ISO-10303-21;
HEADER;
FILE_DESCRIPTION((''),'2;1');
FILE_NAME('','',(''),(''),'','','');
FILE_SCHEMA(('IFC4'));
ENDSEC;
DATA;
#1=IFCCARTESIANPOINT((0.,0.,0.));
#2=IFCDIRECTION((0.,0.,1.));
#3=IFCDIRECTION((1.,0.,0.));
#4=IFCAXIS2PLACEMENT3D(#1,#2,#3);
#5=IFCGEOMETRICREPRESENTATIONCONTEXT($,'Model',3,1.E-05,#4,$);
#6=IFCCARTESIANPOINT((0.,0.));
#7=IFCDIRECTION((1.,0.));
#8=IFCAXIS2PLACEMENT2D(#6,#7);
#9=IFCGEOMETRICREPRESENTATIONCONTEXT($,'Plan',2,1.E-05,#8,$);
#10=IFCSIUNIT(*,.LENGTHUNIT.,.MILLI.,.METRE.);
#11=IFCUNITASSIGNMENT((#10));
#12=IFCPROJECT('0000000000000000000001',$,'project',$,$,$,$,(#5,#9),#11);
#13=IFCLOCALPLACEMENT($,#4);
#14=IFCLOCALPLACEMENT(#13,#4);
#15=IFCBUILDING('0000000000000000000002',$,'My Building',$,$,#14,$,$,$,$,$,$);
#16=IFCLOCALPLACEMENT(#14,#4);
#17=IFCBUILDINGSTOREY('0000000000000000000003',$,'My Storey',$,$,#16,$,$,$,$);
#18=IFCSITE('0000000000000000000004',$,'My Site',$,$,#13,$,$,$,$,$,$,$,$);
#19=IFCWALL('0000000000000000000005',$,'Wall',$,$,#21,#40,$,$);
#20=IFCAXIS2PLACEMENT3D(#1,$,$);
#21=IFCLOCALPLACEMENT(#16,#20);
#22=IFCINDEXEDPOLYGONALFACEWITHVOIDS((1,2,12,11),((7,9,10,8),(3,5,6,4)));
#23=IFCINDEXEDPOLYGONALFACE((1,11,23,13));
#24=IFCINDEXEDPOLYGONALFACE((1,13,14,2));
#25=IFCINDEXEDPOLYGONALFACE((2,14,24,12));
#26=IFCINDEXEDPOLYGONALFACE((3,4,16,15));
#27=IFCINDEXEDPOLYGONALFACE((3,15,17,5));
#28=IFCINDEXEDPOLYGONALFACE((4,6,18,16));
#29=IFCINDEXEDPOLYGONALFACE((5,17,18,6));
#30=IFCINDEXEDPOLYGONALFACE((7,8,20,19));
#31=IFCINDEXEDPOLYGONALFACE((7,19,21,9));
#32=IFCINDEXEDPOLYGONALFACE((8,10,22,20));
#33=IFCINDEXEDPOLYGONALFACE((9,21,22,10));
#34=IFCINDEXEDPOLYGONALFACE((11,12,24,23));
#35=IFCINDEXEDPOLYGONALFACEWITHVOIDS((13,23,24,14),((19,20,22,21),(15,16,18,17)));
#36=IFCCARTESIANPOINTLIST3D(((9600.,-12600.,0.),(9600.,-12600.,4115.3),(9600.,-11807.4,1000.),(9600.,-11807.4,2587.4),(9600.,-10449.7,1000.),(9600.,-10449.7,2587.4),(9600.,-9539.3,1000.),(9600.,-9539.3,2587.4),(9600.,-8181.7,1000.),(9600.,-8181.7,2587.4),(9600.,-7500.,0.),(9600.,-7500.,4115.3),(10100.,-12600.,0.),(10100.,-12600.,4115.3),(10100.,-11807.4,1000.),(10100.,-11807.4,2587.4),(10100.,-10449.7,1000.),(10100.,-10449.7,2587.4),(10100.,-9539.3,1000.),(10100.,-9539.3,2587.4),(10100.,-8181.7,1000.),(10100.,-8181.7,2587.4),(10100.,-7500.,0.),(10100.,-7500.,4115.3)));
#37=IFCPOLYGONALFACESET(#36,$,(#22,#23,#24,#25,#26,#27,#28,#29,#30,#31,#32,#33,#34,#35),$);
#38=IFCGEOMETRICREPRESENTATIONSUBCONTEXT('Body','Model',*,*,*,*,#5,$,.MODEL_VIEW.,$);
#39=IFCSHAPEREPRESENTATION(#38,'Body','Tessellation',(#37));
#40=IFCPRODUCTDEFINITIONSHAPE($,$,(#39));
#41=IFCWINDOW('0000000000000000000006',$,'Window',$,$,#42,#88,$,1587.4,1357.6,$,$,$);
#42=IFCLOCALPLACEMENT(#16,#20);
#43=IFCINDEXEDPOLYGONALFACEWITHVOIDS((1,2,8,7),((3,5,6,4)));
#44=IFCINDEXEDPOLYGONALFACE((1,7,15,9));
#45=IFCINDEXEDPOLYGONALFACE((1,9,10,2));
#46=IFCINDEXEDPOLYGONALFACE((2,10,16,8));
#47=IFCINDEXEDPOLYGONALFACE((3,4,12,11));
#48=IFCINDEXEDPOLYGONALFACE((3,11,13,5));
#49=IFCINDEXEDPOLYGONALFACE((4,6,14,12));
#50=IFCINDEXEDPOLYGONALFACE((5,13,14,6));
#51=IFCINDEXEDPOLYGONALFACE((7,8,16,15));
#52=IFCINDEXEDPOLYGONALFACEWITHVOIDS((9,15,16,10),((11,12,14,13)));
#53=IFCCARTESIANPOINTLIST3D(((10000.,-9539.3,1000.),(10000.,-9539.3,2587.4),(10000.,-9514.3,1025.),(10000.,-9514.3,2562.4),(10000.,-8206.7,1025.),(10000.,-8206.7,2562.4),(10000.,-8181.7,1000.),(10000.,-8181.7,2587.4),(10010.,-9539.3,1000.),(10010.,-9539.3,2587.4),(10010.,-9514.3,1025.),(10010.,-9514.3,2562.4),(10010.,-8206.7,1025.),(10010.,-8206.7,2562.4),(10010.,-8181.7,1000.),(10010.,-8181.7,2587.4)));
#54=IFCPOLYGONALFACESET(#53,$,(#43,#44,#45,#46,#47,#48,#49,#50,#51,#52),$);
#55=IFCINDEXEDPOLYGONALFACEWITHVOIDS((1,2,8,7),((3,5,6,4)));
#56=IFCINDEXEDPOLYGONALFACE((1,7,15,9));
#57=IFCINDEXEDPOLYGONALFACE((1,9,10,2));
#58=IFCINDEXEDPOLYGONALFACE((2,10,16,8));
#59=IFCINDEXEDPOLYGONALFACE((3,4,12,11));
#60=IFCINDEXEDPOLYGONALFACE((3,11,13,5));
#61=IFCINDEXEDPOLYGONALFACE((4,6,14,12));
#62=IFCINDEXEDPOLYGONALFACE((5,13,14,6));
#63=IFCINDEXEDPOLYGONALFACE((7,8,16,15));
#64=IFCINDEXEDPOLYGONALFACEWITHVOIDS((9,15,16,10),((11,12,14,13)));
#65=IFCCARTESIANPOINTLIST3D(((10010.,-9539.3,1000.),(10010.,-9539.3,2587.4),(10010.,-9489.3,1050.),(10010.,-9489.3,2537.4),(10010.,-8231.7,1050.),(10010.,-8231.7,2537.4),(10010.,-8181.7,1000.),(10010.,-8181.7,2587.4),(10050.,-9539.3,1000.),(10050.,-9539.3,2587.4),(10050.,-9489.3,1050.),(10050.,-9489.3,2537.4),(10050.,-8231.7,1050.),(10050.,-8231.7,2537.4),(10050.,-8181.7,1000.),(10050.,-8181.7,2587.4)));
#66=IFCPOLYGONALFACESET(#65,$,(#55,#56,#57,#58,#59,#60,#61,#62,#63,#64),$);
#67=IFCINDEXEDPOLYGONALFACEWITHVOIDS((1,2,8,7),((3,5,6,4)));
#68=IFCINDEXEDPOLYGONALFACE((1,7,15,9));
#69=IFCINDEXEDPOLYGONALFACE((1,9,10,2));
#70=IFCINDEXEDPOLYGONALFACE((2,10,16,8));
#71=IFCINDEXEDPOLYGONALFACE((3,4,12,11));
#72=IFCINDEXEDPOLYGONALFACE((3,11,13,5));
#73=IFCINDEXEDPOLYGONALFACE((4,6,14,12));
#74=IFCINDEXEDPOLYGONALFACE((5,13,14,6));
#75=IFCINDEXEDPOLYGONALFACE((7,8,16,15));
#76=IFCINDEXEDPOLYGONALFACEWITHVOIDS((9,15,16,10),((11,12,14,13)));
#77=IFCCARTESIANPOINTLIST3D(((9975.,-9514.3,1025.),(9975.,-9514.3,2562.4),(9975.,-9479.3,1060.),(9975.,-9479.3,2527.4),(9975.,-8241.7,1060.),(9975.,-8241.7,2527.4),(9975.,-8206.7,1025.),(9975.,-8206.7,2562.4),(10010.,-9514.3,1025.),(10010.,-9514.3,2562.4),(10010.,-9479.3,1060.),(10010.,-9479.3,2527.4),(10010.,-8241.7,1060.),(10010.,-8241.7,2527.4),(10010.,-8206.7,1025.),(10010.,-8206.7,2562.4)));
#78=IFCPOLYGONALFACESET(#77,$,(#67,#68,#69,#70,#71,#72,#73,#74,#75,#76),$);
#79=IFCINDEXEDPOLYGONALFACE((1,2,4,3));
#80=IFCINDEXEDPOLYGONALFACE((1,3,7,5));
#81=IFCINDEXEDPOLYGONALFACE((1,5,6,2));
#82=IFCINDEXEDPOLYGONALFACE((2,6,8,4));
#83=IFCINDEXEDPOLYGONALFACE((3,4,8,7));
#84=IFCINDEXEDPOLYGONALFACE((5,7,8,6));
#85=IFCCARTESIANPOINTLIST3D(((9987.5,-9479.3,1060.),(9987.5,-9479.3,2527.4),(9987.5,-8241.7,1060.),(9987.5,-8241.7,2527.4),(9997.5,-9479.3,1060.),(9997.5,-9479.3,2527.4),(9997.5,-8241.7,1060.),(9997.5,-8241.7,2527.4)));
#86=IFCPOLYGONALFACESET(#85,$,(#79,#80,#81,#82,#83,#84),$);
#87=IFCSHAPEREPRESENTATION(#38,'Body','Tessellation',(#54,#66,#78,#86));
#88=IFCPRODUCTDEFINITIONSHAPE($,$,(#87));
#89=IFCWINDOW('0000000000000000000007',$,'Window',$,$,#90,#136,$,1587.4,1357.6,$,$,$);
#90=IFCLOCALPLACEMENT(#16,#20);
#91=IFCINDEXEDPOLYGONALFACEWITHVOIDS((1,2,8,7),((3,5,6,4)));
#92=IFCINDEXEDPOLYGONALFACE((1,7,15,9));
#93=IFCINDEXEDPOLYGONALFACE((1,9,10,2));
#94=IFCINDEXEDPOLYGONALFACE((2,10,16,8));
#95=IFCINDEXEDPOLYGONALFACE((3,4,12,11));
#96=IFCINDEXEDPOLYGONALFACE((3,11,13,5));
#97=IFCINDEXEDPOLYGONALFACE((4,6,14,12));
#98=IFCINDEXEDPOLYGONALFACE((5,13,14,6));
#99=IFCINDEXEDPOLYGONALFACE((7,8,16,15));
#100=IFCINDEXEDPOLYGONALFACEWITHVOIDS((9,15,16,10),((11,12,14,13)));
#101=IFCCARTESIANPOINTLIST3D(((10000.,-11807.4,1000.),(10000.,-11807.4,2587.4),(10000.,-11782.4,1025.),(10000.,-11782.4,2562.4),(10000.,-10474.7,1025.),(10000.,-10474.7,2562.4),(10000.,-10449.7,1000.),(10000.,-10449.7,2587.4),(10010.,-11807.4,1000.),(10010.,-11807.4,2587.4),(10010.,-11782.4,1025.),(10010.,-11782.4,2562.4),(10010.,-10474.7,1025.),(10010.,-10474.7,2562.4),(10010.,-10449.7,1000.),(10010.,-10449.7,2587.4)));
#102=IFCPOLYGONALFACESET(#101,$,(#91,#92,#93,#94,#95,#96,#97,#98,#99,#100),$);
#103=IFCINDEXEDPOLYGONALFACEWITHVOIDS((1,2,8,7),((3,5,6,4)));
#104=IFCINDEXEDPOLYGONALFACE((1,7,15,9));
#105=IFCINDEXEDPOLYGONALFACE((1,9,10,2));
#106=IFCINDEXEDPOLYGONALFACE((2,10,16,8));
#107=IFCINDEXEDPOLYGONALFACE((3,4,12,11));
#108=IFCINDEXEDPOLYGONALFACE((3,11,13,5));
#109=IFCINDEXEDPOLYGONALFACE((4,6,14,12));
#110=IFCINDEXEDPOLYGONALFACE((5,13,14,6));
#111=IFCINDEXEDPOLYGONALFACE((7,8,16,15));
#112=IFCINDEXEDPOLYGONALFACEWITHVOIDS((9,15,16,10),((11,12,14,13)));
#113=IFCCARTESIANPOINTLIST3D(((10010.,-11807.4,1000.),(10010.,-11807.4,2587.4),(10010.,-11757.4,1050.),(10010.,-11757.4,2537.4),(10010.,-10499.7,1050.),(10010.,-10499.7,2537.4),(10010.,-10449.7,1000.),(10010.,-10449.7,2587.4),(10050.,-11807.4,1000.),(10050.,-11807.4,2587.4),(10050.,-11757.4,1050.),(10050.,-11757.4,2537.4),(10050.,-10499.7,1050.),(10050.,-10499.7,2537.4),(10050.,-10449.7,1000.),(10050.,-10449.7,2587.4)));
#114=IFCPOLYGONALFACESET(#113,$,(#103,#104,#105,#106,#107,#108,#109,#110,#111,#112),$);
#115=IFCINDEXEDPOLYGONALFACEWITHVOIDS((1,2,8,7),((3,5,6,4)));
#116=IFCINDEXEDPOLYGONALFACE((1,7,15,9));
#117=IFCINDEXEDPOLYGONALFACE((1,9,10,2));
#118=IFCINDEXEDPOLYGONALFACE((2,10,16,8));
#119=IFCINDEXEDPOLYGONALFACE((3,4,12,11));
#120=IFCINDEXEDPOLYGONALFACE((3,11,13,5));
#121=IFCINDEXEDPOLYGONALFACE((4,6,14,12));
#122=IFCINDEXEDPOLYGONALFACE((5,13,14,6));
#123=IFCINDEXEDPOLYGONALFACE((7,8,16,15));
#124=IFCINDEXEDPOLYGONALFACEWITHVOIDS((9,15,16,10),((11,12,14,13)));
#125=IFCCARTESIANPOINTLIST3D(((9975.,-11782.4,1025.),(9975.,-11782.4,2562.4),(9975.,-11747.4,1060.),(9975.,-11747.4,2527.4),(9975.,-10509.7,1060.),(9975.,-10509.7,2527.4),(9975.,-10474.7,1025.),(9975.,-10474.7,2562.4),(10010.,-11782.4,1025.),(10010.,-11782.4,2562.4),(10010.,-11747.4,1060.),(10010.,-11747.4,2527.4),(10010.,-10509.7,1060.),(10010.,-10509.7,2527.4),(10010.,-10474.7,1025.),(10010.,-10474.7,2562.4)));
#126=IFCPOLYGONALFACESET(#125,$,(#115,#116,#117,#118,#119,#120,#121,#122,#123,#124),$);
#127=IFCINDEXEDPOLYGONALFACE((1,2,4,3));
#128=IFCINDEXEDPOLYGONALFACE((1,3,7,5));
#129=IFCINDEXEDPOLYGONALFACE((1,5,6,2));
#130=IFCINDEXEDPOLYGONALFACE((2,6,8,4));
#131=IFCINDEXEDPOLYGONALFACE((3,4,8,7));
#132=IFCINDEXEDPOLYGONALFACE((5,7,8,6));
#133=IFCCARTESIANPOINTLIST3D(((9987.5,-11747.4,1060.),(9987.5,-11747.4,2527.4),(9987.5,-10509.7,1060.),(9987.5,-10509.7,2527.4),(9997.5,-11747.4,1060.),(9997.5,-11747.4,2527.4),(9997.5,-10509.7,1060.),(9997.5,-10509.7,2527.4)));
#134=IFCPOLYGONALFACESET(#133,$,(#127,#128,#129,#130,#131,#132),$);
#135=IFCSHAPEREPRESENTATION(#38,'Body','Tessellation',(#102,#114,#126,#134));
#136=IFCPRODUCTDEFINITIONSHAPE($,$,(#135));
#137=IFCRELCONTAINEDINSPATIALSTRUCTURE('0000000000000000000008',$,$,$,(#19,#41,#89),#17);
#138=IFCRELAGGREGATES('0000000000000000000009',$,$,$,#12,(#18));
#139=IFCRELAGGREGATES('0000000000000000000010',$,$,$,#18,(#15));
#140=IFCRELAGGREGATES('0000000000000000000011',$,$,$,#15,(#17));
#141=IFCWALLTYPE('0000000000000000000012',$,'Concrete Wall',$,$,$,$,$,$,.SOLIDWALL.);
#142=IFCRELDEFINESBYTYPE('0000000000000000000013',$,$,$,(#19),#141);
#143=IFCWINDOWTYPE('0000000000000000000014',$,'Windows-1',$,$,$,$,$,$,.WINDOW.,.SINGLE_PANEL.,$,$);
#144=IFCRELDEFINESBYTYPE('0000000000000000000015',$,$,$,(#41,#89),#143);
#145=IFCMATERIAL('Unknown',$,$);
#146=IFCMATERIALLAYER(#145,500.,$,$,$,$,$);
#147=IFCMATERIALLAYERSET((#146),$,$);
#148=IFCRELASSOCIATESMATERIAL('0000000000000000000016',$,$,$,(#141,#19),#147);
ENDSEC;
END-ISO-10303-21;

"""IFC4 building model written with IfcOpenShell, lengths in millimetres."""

from ifc_helpers import new_model, entity, si_unit, frame, origin_with_axes, origin_2d_with_axis, place, context, subcontext, project, spatial, line, indexed_curve, outline, extrude, shape, source, transform, mapped, material, layer, layer_set, layer_usage, type_object, type_shapes, element, fill, save


model = new_model("IFC4")

# Units and contexts
model_context = context("Model", 3, precision=1e-05, world=origin_with_axes())
plan_context = context("Plan", 2, precision=1e-05, world=origin_2d_with_axis())
body_context_1 = subcontext(model_context, "Body", "Model", "MODEL_VIEW")
body_context_2 = subcontext(plan_context, "Body", "Plan", "PLAN_VIEW")
ifc_project = project(units=[si_unit("LENGTHUNIT", "METRE", prefix="MILLI")], contexts=[model_context, plan_context])

# Site, building, storey
site_placement = place(None, origin_with_axes())
site = spatial("IfcSite", under=ifc_project, at=site_placement, Name="My Site")
building_placement = place(site_placement, origin_with_axes())
building = spatial("IfcBuilding", under=site, at=building_placement, Name="My Building")
storey_placement = place(building_placement, origin_with_axes())
storey = spatial("IfcBuildingStorey", under=building, at=storey_placement, Name="My Storey")

# Shared definitions
ifc_material = material(Name="Unknown")

# Wall, openings, windows
ifc_layer_1 = layer(ifc_material, 500.0)
ifc_layer_set_1 = layer_set([ifc_layer_1])
ifc_layer_usage_1 = layer_usage(ifc_layer_set_1, "AXIS2", "POSITIVE", 0.0)
wall_type = type_object("IfcWallType", Name="Concrete Wall", PredefinedType="SOLIDWALL", material=ifc_layer_set_1)
wall_1_placement = place(storey_placement, frame((9600.0, -7500.0, 0.0), z_axis=(0.0, 0.0, 1.0), x_axis=(0.0, -1.0, 0.0)))
wall_1 = element("IfcWall", 1, at=wall_1_placement, inside=storey, type_object=wall_type, material=ifc_layer_usage_1, Name="Wall", context=body_context_1, shape_type="SweptSolid", body=[
    extrude(outline(indexed_curve([(0.0, 0.0), (0.0, 500.0), (5100.0, 500.0), (5100.0, 0.0)], segments=[line(1, 2, 3, 4, 1)])), origin_with_axes(), (0.0, 0.0, 1.0), 4115.3),
])
shared_shape_1 = source(origin_with_axes(), body_context_1, "Body", "SweptSolid", [
    extrude(outline(indexed_curve([(0.0, 0.0), (1357.6, 0.0), (1357.6, 1587.4), (0.0, 1587.4)], segments=[line(1, 2, 3, 4, 1)])), frame((0.0, -600.0, 0.0), z_axis=(0.0, -1.0, 0.0), x_axis=(1.0, 0.0, 0.0)), (0.0, 0.0, -1.0), 1200.0),
])
opening_1_placement = place(wall_1_placement, frame((2039.3, 500.0, 1000.0), z_axis=(0.0, 0.0, 1.0), x_axis=(-1.0, 0.0, 0.0)))
opening_1 = element("IfcOpeningElement", 2, at=opening_1_placement, cuts=wall_1, PredefinedType="OPENING", context=body_context_1, shape_type="MappedRepresentation", body=[
    mapped(shared_shape_1, transform((0.0, 0.0, 0.0), x_axis=(1.0, 0.0, 0.0), y_axis=(0.0, 1.0, 0.0), z_axis=(0.0, 0.0, 1.0), scale=1.0)),
])
opening_2_placement = place(wall_1_placement, frame((4307.4, 500.0, 1000.0), z_axis=(0.0, 0.0, 1.0), x_axis=(-1.0, 0.0, 0.0)))
opening_2 = element("IfcOpeningElement", 3, at=opening_2_placement, cuts=wall_1, PredefinedType="OPENING", context=body_context_1, shape_type="MappedRepresentation", body=[
    mapped(shared_shape_1, transform((0.0, 0.0, 0.0), x_axis=(1.0, 0.0, 0.0), y_axis=(0.0, 1.0, 0.0), z_axis=(0.0, 0.0, 1.0), scale=1.0)),
])
window_type = type_object("IfcWindowType", Name="Windows-1", PartitioningType="SINGLE_PANEL", PredefinedType="WINDOW")
shared_shape_2 = source(origin_with_axes(), body_context_1, "Body", "SweptSolid", [
    extrude(outline(indexed_curve([(0.0, 0.0), (1357.6, 0.0), (1357.6, 1587.4), (0.0, 1587.4)], segments=[line(1, 2, 3, 4, 1)]), holes=[indexed_curve([(25.0, 25.0), (1332.6, 25.0), (1332.6, 1562.4), (25.0, 1562.4)], segments=[line(1, 2, 3, 4, 1)])]), frame((0.0, 90.0, 0.0), z_axis=(0.0, -1.0, 0.0), x_axis=(1.0, 0.0, 0.0)), (0.0, 0.0, -1.0), 10.0),
    extrude(outline(indexed_curve([(0.0, 0.0), (1357.6, 0.0), (1357.6, 1587.4), (0.0, 1587.4)], segments=[line(1, 2, 3, 4, 1)]), holes=[indexed_curve([(50.0, 50.0), (1307.6, 50.0), (1307.6, 1537.4), (50.0, 1537.4)], segments=[line(1, 2, 3, 4, 1)])]), frame((0.0, 50.0, 0.0), z_axis=(0.0, -1.0, 0.0), x_axis=(1.0, 0.0, 0.0)), (0.0, 0.0, -1.0), 40.0),
    extrude(outline(indexed_curve([(0.0, 0.0), (1307.6, 0.0), (1307.6, 1537.4), (0.0, 1537.4)], segments=[line(1, 2, 3, 4, 1)]), holes=[indexed_curve([(35.0, 35.0), (1272.6, 35.0), (1272.6, 1502.4), (35.0, 1502.4)], segments=[line(1, 2, 3, 4, 1)])]), frame((25.0, 90.0, 25.0), z_axis=(0.0, -1.0, 0.0), x_axis=(1.0, 0.0, 0.0)), (0.0, 0.0, -1.0), 35.0),
    extrude(outline(indexed_curve([(35.0, 35.0), (1272.6, 35.0), (1272.6, 1502.4), (35.0, 1502.4)], segments=[line(1, 2, 3, 4, 1)])), frame((25.0, 102.5, 25.0), z_axis=(0.0, -1.0, 0.0), x_axis=(1.0, 0.0, 0.0)), (0.0, 0.0, -1.0), 10.0),
])
shared_shape_3 = source(origin_with_axes(), body_context_2, "Body", "Curve2D", [
    entity("IfcIndexedPolyCurve", entity("IfcCartesianPointList2D", [[50.0, 50.0], [1307.6, 50.0]])),
    entity("IfcIndexedPolyCurve", entity("IfcCartesianPointList2D", [[0.0, 100.0], [25.0, 100.0], [25.0, 90.0], [50.0, 90.0], [50.0, 50.0], [0.0, 50.0]]), [entity("IfcLineIndex", [1, 2, 3, 4, 5, 6, 1])]),
    entity("IfcIndexedPolyCurve", entity("IfcCartesianPointList2D", [[1357.6, 100.0], [1332.6, 100.0], [1332.6, 90.0], [1307.6, 90.0], [1307.6, 50.0], [1357.6, 50.0]]), [entity("IfcLineIndex", [1, 2, 3, 4, 5, 6, 1])]),
    entity("IfcIndexedPolyCurve", entity("IfcCartesianPointList2D", [[25.0, 90.0], [60.0, 90.0], [60.0, 125.0], [25.0, 125.0]]), [entity("IfcLineIndex", [1, 2, 3, 4, 1])]),
    entity("IfcIndexedPolyCurve", entity("IfcCartesianPointList2D", [[1332.6, 90.0], [1297.6, 90.0], [1297.6, 125.0], [1332.6, 125.0]]), [entity("IfcLineIndex", [1, 2, 3, 4, 1])]),
    entity("IfcIndexedPolyCurve", entity("IfcCartesianPointList2D", [[60.0, 90.0], [1297.6, 90.0]])),
    entity("IfcIndexedPolyCurve", entity("IfcCartesianPointList2D", [[60.0, 125.0], [1297.6, 125.0]])),
    entity("IfcIndexedPolyCurve", entity("IfcCartesianPointList2D", [[60.0, 107.5], [1297.6, 107.5]])),
])
type_shapes(window_type, [shared_shape_2, shared_shape_3])
window_1_placement = place(opening_1_placement, frame((0.0, 0.0, 0.0), z_axis=(0.0, 0.0, 1.0), x_axis=(1.0, 0.0, 0.0)))
window_1 = element("IfcWindow", 4, at=window_1_placement, inside=storey, type_object=window_type, Name="Window", OverallHeight=1587.4, OverallWidth=1357.6, shapes=[
    shape(body_context_1, "Body", "MappedRepresentation", [mapped(shared_shape_2, transform((0.0, 0.0, 0.0), x_axis=(1.0, 0.0, 0.0), y_axis=(0.0, 1.0, 0.0), z_axis=(0.0, 0.0, 1.0), scale=1.0))]),
    shape(body_context_2, "Body", "MappedRepresentation", [mapped(shared_shape_3, transform((0.0, 0.0, 0.0), x_axis=(1.0, 0.0, 0.0), y_axis=(0.0, 1.0, 0.0), z_axis=(0.0, 0.0, 1.0), scale=1.0))]),
])
fill(opening_1, window_1)
window_2_placement = place(opening_2_placement, frame((0.0, 0.0, 0.0), z_axis=(0.0, 0.0, 1.0), x_axis=(1.0, 0.0, 0.0)))
window_2 = element("IfcWindow", 5, at=window_2_placement, inside=storey, type_object=window_type, Name="Window", OverallHeight=1587.4, OverallWidth=1357.6, shapes=[
    shape(body_context_1, "Body", "MappedRepresentation", [mapped(shared_shape_2, transform((0.0, 0.0, 0.0), x_axis=(1.0, 0.0, 0.0), y_axis=(0.0, 1.0, 0.0), z_axis=(0.0, 0.0, 1.0), scale=1.0))]),
    shape(body_context_2, "Body", "MappedRepresentation", [mapped(shared_shape_3, transform((0.0, 0.0, 0.0), x_axis=(1.0, 0.0, 0.0), y_axis=(0.0, 1.0, 0.0), z_axis=(0.0, 0.0, 1.0), scale=1.0))]),
])
fill(opening_2, window_2)

save(model, "model.ifc")
